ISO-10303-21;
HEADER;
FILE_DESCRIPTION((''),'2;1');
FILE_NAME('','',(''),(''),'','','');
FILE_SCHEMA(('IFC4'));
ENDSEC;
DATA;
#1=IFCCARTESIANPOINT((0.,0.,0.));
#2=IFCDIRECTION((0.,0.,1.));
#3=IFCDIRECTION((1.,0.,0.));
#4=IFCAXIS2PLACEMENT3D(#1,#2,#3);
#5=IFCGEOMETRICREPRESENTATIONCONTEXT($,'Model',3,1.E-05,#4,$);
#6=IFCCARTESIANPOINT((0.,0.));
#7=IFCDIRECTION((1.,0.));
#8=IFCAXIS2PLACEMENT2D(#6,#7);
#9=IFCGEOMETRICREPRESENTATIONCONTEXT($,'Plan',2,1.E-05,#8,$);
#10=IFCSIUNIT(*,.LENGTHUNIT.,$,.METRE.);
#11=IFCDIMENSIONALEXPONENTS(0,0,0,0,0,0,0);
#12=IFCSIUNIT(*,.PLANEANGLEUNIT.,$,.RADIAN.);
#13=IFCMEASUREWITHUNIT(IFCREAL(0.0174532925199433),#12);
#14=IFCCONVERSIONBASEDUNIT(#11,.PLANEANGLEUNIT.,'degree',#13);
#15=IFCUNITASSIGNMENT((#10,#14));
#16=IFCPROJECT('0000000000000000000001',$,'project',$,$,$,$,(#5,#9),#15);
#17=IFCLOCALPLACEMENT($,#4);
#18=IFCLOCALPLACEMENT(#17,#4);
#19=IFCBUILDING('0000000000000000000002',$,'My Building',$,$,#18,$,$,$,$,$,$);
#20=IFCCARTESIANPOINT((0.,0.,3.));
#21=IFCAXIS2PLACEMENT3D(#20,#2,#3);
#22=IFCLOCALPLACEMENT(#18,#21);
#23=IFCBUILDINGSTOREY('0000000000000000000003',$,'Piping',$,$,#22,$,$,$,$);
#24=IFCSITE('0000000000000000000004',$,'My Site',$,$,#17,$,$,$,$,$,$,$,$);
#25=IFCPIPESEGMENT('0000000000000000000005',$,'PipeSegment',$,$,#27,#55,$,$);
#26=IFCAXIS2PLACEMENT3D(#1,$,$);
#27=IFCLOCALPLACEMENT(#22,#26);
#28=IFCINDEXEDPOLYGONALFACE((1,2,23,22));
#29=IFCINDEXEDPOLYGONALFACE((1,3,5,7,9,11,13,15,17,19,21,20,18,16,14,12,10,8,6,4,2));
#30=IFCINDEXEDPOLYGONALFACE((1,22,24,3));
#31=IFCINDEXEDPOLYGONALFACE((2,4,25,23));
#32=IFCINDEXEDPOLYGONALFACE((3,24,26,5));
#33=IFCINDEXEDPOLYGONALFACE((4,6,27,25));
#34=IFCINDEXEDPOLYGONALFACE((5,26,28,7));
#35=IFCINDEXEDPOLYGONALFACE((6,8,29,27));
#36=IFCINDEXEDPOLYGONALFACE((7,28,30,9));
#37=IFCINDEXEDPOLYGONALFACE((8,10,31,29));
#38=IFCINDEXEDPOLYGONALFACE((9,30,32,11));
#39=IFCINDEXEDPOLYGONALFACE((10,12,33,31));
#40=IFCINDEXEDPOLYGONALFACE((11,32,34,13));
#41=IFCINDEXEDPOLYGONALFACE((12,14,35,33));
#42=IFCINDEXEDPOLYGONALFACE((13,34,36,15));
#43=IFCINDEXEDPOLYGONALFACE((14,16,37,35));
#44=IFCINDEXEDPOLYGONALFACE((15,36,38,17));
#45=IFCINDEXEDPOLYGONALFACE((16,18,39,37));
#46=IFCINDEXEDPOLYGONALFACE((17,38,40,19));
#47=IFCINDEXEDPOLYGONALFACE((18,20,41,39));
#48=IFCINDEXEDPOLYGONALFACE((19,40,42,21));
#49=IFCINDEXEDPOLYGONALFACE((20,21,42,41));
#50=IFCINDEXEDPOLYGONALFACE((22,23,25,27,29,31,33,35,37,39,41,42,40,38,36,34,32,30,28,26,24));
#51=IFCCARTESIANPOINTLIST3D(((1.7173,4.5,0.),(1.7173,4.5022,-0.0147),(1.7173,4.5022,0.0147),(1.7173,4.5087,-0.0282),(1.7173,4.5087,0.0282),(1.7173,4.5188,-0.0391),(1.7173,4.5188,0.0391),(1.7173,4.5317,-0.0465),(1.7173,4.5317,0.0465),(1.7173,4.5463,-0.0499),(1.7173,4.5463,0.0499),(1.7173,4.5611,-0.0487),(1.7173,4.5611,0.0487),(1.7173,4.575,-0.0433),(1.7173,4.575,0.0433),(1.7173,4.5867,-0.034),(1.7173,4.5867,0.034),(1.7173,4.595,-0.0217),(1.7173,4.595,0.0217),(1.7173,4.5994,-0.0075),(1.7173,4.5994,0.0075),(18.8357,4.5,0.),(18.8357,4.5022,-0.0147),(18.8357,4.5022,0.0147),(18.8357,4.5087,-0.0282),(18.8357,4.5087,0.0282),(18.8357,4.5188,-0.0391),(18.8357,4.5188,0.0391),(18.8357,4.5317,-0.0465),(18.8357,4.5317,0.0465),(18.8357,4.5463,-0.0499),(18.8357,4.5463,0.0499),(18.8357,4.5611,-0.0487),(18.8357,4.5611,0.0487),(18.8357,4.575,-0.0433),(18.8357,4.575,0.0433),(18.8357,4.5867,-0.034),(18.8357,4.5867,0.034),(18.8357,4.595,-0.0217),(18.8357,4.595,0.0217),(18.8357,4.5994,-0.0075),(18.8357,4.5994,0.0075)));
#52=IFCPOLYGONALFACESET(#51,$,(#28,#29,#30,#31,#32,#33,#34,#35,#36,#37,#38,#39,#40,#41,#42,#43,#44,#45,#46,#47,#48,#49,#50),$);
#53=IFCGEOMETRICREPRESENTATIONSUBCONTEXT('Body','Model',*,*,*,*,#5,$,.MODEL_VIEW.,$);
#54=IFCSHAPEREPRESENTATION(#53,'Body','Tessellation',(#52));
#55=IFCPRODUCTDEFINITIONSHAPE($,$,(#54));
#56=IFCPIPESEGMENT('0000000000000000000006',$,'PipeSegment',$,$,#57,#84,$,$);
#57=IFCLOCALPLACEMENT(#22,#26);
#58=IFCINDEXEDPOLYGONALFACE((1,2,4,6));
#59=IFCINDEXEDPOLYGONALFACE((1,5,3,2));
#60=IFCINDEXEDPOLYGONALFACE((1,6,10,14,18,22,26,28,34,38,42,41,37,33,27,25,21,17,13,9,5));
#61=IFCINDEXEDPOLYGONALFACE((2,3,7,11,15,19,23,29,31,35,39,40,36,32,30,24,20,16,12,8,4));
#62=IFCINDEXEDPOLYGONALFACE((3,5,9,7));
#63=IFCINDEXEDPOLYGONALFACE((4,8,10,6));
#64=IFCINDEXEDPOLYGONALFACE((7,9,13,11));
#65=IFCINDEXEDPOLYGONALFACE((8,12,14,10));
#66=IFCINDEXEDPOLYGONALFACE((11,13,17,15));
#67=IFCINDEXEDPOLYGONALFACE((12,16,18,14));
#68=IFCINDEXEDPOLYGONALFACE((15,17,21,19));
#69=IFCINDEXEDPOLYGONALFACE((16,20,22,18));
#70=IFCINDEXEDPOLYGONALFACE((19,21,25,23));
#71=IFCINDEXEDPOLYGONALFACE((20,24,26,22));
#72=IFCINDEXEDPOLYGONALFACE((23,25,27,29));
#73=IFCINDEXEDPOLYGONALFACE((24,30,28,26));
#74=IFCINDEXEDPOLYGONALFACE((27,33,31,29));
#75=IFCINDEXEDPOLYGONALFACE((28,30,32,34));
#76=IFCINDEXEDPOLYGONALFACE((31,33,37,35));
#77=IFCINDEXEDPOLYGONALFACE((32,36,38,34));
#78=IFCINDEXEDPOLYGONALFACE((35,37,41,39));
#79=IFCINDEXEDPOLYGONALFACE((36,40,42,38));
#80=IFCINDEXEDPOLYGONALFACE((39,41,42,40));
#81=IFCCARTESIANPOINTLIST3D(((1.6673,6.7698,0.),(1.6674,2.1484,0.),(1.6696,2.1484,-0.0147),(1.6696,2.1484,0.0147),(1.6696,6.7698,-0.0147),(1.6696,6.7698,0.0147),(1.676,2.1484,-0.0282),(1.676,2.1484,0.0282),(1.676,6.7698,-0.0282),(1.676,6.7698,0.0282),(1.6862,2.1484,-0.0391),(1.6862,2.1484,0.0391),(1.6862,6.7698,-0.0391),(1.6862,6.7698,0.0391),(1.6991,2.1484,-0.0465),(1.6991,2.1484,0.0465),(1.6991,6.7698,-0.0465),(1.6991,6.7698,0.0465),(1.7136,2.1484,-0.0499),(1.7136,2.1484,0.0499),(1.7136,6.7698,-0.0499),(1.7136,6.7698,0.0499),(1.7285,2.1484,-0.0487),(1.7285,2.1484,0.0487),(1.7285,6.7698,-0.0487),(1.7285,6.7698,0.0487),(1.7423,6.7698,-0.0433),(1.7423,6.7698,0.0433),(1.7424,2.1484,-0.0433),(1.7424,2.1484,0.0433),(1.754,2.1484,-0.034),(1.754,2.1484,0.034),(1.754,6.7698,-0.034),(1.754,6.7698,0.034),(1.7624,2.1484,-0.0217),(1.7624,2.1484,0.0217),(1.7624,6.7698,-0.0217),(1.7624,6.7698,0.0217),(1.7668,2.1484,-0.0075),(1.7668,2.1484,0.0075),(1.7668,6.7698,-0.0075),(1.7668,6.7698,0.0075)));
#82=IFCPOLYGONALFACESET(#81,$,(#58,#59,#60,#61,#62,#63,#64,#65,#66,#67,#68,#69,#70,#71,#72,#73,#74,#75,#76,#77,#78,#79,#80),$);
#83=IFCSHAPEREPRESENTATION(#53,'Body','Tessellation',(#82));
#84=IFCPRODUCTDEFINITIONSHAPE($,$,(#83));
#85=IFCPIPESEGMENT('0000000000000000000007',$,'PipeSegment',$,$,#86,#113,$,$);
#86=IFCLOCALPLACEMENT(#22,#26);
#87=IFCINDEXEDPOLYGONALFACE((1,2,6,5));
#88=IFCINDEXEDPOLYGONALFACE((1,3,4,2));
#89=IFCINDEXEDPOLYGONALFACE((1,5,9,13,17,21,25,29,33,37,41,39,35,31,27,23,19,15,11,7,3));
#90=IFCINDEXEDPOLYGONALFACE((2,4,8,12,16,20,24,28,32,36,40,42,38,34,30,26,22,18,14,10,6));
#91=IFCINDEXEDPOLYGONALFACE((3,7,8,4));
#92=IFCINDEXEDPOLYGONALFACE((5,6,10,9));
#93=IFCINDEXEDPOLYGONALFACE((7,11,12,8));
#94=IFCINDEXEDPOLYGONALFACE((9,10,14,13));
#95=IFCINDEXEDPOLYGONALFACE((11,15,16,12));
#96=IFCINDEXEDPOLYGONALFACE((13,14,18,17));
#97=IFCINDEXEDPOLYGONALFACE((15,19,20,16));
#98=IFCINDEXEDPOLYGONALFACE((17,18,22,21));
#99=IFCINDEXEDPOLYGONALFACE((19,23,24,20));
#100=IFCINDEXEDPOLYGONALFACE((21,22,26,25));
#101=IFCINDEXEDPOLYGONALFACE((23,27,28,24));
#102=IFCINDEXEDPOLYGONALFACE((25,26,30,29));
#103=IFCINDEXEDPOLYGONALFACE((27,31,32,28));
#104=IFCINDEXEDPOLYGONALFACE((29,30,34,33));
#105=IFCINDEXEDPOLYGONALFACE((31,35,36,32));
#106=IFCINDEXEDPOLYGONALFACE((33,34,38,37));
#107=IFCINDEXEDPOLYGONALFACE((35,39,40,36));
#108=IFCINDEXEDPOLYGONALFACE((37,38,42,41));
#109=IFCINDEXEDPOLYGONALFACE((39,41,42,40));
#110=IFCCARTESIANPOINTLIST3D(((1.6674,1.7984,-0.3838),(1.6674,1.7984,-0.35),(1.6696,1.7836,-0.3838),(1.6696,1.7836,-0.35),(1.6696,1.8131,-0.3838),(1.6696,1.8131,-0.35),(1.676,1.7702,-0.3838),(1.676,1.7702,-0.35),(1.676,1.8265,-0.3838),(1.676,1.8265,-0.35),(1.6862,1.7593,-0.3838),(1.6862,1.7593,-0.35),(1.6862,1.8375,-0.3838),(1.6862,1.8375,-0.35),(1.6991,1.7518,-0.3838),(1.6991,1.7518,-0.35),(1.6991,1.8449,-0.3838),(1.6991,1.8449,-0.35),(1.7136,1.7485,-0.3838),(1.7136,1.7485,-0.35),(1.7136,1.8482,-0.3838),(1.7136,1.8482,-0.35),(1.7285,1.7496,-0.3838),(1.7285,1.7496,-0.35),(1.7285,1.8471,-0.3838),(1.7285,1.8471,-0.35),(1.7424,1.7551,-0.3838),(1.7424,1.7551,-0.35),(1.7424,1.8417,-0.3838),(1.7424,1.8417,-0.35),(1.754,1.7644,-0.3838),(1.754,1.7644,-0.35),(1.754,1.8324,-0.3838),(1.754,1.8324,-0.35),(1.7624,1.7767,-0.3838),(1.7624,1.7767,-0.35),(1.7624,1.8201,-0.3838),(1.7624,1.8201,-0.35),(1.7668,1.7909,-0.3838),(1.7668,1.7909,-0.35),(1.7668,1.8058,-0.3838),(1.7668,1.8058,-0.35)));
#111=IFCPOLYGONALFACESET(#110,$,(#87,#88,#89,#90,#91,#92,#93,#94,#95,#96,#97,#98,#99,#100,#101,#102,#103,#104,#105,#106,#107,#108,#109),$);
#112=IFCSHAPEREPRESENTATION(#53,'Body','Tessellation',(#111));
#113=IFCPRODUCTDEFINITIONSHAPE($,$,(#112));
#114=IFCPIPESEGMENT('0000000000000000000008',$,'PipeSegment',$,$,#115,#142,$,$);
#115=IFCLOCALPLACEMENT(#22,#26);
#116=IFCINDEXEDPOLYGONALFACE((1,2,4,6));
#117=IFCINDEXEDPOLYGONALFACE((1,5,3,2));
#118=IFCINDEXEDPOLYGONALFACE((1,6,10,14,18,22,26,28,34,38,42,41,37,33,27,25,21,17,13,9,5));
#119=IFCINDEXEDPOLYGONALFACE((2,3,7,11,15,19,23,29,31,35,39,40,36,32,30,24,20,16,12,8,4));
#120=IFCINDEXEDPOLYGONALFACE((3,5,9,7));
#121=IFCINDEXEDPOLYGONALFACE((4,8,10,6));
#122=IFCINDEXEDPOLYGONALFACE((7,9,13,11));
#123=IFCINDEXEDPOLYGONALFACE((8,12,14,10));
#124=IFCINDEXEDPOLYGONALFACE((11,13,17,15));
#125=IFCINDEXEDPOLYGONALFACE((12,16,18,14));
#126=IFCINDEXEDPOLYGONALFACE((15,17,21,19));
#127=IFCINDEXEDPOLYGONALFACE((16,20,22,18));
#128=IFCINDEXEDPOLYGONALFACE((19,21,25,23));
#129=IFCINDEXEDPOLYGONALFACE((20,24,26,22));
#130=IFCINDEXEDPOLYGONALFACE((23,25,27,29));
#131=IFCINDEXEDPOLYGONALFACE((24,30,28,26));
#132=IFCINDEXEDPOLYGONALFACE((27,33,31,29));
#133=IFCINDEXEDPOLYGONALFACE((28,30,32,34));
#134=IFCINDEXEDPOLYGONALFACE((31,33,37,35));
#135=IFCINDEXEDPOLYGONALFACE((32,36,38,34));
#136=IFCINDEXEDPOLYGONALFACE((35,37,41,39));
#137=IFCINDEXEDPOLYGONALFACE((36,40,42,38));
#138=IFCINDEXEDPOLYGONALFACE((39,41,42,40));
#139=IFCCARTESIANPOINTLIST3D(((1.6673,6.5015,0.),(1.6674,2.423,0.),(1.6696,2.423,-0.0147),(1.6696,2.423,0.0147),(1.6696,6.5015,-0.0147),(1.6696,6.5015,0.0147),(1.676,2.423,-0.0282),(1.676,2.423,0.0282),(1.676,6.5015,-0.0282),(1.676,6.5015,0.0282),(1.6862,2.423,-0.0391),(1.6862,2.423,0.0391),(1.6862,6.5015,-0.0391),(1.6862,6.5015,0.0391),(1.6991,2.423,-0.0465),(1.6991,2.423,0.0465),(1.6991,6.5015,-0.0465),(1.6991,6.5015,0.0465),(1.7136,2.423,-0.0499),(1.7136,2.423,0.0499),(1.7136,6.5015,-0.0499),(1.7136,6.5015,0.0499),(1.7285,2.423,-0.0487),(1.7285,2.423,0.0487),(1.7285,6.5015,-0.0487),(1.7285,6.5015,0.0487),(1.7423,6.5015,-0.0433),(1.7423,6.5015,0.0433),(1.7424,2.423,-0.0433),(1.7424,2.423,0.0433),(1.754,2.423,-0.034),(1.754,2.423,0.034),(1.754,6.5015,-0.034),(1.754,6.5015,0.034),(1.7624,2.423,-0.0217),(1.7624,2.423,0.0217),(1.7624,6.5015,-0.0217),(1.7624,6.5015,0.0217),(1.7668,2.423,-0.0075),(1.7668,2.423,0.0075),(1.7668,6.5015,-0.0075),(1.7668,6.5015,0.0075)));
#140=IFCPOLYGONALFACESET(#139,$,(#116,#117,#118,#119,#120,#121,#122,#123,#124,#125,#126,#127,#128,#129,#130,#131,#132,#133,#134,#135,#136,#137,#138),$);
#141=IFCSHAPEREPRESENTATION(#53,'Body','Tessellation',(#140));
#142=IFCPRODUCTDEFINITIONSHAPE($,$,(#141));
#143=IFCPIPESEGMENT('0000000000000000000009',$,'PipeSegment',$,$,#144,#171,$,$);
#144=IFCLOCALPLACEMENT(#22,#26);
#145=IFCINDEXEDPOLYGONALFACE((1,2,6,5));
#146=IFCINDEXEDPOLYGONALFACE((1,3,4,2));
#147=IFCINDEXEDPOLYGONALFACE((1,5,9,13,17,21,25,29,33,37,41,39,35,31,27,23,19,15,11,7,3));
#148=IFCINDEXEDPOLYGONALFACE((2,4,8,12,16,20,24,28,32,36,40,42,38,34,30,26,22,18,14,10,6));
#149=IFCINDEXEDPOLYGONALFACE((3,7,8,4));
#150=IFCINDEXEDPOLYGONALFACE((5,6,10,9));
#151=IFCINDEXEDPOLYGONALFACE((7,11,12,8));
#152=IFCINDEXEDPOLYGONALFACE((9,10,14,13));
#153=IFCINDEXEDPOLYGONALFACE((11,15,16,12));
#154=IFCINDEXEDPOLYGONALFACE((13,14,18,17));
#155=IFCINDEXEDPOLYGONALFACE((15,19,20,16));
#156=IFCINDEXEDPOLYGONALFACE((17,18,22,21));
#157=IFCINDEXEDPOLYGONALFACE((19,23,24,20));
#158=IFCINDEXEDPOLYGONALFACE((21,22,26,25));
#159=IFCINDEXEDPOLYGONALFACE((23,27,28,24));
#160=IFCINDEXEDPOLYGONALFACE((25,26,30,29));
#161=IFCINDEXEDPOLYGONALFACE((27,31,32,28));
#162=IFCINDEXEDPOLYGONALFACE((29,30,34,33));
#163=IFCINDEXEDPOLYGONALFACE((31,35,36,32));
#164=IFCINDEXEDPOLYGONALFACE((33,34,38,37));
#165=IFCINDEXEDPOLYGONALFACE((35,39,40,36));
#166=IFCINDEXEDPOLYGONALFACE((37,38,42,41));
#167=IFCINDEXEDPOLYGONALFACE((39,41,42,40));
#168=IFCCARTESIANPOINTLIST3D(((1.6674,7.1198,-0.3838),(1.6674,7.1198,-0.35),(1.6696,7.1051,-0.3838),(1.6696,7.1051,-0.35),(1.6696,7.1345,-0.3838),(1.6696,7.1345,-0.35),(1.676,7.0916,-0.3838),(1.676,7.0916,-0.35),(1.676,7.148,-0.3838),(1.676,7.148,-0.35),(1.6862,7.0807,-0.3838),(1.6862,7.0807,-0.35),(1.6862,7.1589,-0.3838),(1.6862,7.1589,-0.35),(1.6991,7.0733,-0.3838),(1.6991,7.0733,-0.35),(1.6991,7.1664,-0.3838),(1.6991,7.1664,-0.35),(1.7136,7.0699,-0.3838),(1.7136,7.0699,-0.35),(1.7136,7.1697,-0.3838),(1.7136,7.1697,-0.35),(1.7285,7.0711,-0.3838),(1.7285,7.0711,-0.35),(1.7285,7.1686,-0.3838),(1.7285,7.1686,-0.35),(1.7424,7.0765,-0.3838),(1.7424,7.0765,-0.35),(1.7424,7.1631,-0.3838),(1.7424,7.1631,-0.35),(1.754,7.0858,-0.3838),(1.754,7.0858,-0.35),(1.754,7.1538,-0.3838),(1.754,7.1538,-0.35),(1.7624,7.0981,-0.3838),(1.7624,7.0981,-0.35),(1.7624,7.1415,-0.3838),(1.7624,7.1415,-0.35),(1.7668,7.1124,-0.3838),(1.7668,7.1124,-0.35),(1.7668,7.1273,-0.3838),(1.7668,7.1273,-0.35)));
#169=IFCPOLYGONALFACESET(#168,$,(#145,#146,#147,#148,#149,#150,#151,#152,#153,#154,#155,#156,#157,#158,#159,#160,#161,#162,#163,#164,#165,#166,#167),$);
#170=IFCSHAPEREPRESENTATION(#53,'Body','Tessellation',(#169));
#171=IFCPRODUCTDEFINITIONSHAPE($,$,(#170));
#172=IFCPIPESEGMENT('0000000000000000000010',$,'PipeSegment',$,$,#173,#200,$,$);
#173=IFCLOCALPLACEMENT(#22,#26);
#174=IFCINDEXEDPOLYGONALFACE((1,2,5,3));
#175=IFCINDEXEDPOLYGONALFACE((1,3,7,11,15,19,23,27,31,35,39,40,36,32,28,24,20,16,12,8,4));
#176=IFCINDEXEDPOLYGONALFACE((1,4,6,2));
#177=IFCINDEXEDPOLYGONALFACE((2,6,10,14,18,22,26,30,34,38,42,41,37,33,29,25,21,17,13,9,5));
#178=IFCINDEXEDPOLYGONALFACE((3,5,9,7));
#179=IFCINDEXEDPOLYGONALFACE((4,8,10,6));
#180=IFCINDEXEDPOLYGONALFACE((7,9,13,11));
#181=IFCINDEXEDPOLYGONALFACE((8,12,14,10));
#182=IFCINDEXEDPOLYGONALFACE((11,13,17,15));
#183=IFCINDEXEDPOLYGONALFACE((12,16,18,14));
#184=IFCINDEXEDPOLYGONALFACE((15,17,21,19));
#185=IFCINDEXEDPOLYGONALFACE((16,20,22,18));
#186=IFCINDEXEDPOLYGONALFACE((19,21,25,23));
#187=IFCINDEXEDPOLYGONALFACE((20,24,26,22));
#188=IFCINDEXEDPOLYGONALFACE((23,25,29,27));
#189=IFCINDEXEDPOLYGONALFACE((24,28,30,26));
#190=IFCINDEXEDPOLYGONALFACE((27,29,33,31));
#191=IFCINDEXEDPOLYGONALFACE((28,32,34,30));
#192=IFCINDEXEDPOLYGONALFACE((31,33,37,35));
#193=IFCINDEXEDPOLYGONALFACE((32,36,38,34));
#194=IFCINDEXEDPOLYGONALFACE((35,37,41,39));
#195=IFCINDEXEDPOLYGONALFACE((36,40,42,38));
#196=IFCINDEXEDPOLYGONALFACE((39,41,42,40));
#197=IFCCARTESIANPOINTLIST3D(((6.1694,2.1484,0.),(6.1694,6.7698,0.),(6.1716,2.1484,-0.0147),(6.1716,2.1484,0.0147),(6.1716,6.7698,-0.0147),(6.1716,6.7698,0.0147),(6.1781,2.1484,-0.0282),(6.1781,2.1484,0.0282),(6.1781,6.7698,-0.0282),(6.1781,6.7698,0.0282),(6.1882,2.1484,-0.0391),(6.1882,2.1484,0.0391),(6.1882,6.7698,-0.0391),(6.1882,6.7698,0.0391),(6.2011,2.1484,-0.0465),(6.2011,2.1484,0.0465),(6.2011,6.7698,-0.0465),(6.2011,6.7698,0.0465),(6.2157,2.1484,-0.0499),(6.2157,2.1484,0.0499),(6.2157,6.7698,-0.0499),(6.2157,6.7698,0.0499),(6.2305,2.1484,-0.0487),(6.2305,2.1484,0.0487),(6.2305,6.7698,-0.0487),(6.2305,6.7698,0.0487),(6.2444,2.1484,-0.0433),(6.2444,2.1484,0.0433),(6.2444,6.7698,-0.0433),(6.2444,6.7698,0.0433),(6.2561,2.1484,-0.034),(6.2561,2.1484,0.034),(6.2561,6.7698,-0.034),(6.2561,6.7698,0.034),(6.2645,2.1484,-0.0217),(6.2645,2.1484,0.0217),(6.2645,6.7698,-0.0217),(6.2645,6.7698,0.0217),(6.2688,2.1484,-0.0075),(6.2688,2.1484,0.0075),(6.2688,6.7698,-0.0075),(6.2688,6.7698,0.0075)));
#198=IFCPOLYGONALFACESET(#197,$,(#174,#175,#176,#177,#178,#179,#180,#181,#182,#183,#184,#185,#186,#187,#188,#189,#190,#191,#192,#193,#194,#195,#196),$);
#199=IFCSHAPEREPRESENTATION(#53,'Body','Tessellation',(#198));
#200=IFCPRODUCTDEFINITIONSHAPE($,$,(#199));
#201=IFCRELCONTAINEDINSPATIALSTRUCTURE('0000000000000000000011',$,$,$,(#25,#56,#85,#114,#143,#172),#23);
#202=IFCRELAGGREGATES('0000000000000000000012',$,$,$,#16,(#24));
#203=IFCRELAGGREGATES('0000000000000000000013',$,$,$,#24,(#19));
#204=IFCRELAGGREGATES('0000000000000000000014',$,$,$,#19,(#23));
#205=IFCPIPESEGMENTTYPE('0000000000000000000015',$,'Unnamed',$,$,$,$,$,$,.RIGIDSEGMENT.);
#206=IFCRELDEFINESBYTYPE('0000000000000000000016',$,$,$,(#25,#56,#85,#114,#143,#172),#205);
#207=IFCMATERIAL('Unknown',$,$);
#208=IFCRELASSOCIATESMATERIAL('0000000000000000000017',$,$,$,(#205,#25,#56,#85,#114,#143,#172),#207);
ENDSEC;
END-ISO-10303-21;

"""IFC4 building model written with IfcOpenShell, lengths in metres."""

from ifc_helpers import new_model, entity, si_unit, converted_unit, frame, origin_with_axes, origin_2d_with_axis, place, context, subcontext, project, spatial, circle, extrude, material, material_profile, profile_set, profile_usage, type_object, element, save


model = new_model("IFC4")

# Units and contexts
model_context = context("Model", 3, precision=1e-05, world=origin_with_axes())
plan_context = context("Plan", 2, precision=1e-05, world=origin_2d_with_axis())
body_context = subcontext(model_context, "Body", "Model", "MODEL_VIEW")
ifc_project = project(units=[si_unit("LENGTHUNIT", "METRE"), converted_unit("PLANEANGLEUNIT", "degree", entity("IfcReal", 0.0174532925199433), si_unit("PLANEANGLEUNIT", "RADIAN"), dimensions=[0, 0, 0, 0, 0, 0, 0])], contexts=[model_context, plan_context])

# Site, building, storey
site_placement = place(None, origin_with_axes())
site = spatial("IfcSite", under=ifc_project, at=site_placement, Name="My Site")
building_placement = place(site_placement, origin_with_axes())
building = spatial("IfcBuilding", under=site, at=building_placement, Name="My Building")
storey_placement = place(building_placement, frame((0.0, 0.0, 3.0), z_axis=(0.0, 0.0, 1.0), x_axis=(1.0, 0.0, 0.0)))
storey = spatial("IfcBuildingStorey", under=building, at=storey_placement, Name="Piping")

# Pipe segments
ifc_material = material(Name="Unknown")
ifc_material_profile = material_profile(ifc_material, circle(Radius=0.05))
ifc_profile_set = profile_set([ifc_material_profile])
ifc_profile_usage_1 = profile_usage(ifc_profile_set, cardinal=5)
pipe_segment_type = type_object("IfcPipeSegmentType", Name="Unnamed", PredefinedType="RIGIDSEGMENT", material=ifc_profile_set)
pipe_segment_1_placement = place(storey_placement, frame((18.8357, 4.55, 0.0), z_axis=(-1.0, 0.0, 0.0), x_axis=(0.0, -1.0, 0.0)))
element("IfcPipeSegment", 1, at=pipe_segment_1_placement, inside=storey, type_object=pipe_segment_type, material=ifc_profile_usage_1, Name="PipeSegment", context=body_context, shape_type="SweptSolid", body=[
    extrude(circle(Radius=0.05), origin_with_axes(), (0.0, 0.0, 1.0), 17.1184),
])
ifc_profile_usage_2 = profile_usage(ifc_profile_set, cardinal=5)
pipe_segment_2_placement = place(storey_placement, frame((1.7174, 2.1484, 0.0), z_axis=(0.0, 1.0, 0.0), x_axis=(-1.0, 0.0, 0.0)))
element("IfcPipeSegment", 2, at=pipe_segment_2_placement, inside=storey, type_object=pipe_segment_type, material=ifc_profile_usage_2, Name="PipeSegment", context=body_context, shape_type="SweptSolid", body=[
    extrude(circle(Radius=0.05), origin_with_axes(), (0.0, 0.0, 1.0), 4.6214),
])
ifc_profile_usage_3 = profile_usage(ifc_profile_set, cardinal=5)
pipe_segment_3_placement = place(storey_placement, frame((1.7174, 1.7984, -0.35), z_axis=(0.0, 0.0, -1.0), x_axis=(-1.0, 0.0, 0.0)))
element("IfcPipeSegment", 3, at=pipe_segment_3_placement, inside=storey, type_object=pipe_segment_type, material=ifc_profile_usage_3, Name="PipeSegment", context=body_context, shape_type="SweptSolid", body=[
    extrude(circle(Radius=0.05), origin_with_axes(), (0.0, 0.0, 1.0), 0.0338),
])
ifc_profile_usage_4 = profile_usage(ifc_profile_set, cardinal=5)
pipe_segment_4_placement = place(storey_placement, frame((1.7174, 2.423, 0.0), z_axis=(0.0, 1.0, 0.0), x_axis=(-1.0, 0.0, 0.0)))
element("IfcPipeSegment", 4, at=pipe_segment_4_placement, inside=storey, type_object=pipe_segment_type, material=ifc_profile_usage_4, Name="PipeSegment", context=body_context, shape_type="SweptSolid", body=[
    extrude(circle(Radius=0.05), origin_with_axes(), (0.0, 0.0, 1.0), 4.0785),
])

# Pipe segments
ifc_profile_usage_5 = profile_usage(ifc_profile_set, cardinal=5)
pipe_segment_5_placement = place(storey_placement, frame((1.7174, 7.1198, -0.35), z_axis=(0.0, 0.0, -1.0), x_axis=(-1.0, 0.0, 0.0)))
element("IfcPipeSegment", 5, at=pipe_segment_5_placement, inside=storey, type_object=pipe_segment_type, material=ifc_profile_usage_5, Name="PipeSegment", context=body_context, shape_type="SweptSolid", body=[
    extrude(circle(Radius=0.05), origin_with_axes(), (0.0, 0.0, 1.0), 0.0338),
])
ifc_profile_usage_6 = profile_usage(ifc_profile_set, cardinal=5)
pipe_segment_6_placement = place(storey_placement, frame((6.2194, 2.1484, 0.0), z_axis=(0.0, 1.0, 0.0), x_axis=(-1.0, 0.0, 0.0)))
element("IfcPipeSegment", 6, at=pipe_segment_6_placement, inside=storey, type_object=pipe_segment_type, material=ifc_profile_usage_6, Name="PipeSegment", context=body_context, shape_type="SweptSolid", body=[
    extrude(circle(Radius=0.05), origin_with_axes(), (0.0, 0.0, 1.0), 4.6214),
])

save(model, "model.ifc")
